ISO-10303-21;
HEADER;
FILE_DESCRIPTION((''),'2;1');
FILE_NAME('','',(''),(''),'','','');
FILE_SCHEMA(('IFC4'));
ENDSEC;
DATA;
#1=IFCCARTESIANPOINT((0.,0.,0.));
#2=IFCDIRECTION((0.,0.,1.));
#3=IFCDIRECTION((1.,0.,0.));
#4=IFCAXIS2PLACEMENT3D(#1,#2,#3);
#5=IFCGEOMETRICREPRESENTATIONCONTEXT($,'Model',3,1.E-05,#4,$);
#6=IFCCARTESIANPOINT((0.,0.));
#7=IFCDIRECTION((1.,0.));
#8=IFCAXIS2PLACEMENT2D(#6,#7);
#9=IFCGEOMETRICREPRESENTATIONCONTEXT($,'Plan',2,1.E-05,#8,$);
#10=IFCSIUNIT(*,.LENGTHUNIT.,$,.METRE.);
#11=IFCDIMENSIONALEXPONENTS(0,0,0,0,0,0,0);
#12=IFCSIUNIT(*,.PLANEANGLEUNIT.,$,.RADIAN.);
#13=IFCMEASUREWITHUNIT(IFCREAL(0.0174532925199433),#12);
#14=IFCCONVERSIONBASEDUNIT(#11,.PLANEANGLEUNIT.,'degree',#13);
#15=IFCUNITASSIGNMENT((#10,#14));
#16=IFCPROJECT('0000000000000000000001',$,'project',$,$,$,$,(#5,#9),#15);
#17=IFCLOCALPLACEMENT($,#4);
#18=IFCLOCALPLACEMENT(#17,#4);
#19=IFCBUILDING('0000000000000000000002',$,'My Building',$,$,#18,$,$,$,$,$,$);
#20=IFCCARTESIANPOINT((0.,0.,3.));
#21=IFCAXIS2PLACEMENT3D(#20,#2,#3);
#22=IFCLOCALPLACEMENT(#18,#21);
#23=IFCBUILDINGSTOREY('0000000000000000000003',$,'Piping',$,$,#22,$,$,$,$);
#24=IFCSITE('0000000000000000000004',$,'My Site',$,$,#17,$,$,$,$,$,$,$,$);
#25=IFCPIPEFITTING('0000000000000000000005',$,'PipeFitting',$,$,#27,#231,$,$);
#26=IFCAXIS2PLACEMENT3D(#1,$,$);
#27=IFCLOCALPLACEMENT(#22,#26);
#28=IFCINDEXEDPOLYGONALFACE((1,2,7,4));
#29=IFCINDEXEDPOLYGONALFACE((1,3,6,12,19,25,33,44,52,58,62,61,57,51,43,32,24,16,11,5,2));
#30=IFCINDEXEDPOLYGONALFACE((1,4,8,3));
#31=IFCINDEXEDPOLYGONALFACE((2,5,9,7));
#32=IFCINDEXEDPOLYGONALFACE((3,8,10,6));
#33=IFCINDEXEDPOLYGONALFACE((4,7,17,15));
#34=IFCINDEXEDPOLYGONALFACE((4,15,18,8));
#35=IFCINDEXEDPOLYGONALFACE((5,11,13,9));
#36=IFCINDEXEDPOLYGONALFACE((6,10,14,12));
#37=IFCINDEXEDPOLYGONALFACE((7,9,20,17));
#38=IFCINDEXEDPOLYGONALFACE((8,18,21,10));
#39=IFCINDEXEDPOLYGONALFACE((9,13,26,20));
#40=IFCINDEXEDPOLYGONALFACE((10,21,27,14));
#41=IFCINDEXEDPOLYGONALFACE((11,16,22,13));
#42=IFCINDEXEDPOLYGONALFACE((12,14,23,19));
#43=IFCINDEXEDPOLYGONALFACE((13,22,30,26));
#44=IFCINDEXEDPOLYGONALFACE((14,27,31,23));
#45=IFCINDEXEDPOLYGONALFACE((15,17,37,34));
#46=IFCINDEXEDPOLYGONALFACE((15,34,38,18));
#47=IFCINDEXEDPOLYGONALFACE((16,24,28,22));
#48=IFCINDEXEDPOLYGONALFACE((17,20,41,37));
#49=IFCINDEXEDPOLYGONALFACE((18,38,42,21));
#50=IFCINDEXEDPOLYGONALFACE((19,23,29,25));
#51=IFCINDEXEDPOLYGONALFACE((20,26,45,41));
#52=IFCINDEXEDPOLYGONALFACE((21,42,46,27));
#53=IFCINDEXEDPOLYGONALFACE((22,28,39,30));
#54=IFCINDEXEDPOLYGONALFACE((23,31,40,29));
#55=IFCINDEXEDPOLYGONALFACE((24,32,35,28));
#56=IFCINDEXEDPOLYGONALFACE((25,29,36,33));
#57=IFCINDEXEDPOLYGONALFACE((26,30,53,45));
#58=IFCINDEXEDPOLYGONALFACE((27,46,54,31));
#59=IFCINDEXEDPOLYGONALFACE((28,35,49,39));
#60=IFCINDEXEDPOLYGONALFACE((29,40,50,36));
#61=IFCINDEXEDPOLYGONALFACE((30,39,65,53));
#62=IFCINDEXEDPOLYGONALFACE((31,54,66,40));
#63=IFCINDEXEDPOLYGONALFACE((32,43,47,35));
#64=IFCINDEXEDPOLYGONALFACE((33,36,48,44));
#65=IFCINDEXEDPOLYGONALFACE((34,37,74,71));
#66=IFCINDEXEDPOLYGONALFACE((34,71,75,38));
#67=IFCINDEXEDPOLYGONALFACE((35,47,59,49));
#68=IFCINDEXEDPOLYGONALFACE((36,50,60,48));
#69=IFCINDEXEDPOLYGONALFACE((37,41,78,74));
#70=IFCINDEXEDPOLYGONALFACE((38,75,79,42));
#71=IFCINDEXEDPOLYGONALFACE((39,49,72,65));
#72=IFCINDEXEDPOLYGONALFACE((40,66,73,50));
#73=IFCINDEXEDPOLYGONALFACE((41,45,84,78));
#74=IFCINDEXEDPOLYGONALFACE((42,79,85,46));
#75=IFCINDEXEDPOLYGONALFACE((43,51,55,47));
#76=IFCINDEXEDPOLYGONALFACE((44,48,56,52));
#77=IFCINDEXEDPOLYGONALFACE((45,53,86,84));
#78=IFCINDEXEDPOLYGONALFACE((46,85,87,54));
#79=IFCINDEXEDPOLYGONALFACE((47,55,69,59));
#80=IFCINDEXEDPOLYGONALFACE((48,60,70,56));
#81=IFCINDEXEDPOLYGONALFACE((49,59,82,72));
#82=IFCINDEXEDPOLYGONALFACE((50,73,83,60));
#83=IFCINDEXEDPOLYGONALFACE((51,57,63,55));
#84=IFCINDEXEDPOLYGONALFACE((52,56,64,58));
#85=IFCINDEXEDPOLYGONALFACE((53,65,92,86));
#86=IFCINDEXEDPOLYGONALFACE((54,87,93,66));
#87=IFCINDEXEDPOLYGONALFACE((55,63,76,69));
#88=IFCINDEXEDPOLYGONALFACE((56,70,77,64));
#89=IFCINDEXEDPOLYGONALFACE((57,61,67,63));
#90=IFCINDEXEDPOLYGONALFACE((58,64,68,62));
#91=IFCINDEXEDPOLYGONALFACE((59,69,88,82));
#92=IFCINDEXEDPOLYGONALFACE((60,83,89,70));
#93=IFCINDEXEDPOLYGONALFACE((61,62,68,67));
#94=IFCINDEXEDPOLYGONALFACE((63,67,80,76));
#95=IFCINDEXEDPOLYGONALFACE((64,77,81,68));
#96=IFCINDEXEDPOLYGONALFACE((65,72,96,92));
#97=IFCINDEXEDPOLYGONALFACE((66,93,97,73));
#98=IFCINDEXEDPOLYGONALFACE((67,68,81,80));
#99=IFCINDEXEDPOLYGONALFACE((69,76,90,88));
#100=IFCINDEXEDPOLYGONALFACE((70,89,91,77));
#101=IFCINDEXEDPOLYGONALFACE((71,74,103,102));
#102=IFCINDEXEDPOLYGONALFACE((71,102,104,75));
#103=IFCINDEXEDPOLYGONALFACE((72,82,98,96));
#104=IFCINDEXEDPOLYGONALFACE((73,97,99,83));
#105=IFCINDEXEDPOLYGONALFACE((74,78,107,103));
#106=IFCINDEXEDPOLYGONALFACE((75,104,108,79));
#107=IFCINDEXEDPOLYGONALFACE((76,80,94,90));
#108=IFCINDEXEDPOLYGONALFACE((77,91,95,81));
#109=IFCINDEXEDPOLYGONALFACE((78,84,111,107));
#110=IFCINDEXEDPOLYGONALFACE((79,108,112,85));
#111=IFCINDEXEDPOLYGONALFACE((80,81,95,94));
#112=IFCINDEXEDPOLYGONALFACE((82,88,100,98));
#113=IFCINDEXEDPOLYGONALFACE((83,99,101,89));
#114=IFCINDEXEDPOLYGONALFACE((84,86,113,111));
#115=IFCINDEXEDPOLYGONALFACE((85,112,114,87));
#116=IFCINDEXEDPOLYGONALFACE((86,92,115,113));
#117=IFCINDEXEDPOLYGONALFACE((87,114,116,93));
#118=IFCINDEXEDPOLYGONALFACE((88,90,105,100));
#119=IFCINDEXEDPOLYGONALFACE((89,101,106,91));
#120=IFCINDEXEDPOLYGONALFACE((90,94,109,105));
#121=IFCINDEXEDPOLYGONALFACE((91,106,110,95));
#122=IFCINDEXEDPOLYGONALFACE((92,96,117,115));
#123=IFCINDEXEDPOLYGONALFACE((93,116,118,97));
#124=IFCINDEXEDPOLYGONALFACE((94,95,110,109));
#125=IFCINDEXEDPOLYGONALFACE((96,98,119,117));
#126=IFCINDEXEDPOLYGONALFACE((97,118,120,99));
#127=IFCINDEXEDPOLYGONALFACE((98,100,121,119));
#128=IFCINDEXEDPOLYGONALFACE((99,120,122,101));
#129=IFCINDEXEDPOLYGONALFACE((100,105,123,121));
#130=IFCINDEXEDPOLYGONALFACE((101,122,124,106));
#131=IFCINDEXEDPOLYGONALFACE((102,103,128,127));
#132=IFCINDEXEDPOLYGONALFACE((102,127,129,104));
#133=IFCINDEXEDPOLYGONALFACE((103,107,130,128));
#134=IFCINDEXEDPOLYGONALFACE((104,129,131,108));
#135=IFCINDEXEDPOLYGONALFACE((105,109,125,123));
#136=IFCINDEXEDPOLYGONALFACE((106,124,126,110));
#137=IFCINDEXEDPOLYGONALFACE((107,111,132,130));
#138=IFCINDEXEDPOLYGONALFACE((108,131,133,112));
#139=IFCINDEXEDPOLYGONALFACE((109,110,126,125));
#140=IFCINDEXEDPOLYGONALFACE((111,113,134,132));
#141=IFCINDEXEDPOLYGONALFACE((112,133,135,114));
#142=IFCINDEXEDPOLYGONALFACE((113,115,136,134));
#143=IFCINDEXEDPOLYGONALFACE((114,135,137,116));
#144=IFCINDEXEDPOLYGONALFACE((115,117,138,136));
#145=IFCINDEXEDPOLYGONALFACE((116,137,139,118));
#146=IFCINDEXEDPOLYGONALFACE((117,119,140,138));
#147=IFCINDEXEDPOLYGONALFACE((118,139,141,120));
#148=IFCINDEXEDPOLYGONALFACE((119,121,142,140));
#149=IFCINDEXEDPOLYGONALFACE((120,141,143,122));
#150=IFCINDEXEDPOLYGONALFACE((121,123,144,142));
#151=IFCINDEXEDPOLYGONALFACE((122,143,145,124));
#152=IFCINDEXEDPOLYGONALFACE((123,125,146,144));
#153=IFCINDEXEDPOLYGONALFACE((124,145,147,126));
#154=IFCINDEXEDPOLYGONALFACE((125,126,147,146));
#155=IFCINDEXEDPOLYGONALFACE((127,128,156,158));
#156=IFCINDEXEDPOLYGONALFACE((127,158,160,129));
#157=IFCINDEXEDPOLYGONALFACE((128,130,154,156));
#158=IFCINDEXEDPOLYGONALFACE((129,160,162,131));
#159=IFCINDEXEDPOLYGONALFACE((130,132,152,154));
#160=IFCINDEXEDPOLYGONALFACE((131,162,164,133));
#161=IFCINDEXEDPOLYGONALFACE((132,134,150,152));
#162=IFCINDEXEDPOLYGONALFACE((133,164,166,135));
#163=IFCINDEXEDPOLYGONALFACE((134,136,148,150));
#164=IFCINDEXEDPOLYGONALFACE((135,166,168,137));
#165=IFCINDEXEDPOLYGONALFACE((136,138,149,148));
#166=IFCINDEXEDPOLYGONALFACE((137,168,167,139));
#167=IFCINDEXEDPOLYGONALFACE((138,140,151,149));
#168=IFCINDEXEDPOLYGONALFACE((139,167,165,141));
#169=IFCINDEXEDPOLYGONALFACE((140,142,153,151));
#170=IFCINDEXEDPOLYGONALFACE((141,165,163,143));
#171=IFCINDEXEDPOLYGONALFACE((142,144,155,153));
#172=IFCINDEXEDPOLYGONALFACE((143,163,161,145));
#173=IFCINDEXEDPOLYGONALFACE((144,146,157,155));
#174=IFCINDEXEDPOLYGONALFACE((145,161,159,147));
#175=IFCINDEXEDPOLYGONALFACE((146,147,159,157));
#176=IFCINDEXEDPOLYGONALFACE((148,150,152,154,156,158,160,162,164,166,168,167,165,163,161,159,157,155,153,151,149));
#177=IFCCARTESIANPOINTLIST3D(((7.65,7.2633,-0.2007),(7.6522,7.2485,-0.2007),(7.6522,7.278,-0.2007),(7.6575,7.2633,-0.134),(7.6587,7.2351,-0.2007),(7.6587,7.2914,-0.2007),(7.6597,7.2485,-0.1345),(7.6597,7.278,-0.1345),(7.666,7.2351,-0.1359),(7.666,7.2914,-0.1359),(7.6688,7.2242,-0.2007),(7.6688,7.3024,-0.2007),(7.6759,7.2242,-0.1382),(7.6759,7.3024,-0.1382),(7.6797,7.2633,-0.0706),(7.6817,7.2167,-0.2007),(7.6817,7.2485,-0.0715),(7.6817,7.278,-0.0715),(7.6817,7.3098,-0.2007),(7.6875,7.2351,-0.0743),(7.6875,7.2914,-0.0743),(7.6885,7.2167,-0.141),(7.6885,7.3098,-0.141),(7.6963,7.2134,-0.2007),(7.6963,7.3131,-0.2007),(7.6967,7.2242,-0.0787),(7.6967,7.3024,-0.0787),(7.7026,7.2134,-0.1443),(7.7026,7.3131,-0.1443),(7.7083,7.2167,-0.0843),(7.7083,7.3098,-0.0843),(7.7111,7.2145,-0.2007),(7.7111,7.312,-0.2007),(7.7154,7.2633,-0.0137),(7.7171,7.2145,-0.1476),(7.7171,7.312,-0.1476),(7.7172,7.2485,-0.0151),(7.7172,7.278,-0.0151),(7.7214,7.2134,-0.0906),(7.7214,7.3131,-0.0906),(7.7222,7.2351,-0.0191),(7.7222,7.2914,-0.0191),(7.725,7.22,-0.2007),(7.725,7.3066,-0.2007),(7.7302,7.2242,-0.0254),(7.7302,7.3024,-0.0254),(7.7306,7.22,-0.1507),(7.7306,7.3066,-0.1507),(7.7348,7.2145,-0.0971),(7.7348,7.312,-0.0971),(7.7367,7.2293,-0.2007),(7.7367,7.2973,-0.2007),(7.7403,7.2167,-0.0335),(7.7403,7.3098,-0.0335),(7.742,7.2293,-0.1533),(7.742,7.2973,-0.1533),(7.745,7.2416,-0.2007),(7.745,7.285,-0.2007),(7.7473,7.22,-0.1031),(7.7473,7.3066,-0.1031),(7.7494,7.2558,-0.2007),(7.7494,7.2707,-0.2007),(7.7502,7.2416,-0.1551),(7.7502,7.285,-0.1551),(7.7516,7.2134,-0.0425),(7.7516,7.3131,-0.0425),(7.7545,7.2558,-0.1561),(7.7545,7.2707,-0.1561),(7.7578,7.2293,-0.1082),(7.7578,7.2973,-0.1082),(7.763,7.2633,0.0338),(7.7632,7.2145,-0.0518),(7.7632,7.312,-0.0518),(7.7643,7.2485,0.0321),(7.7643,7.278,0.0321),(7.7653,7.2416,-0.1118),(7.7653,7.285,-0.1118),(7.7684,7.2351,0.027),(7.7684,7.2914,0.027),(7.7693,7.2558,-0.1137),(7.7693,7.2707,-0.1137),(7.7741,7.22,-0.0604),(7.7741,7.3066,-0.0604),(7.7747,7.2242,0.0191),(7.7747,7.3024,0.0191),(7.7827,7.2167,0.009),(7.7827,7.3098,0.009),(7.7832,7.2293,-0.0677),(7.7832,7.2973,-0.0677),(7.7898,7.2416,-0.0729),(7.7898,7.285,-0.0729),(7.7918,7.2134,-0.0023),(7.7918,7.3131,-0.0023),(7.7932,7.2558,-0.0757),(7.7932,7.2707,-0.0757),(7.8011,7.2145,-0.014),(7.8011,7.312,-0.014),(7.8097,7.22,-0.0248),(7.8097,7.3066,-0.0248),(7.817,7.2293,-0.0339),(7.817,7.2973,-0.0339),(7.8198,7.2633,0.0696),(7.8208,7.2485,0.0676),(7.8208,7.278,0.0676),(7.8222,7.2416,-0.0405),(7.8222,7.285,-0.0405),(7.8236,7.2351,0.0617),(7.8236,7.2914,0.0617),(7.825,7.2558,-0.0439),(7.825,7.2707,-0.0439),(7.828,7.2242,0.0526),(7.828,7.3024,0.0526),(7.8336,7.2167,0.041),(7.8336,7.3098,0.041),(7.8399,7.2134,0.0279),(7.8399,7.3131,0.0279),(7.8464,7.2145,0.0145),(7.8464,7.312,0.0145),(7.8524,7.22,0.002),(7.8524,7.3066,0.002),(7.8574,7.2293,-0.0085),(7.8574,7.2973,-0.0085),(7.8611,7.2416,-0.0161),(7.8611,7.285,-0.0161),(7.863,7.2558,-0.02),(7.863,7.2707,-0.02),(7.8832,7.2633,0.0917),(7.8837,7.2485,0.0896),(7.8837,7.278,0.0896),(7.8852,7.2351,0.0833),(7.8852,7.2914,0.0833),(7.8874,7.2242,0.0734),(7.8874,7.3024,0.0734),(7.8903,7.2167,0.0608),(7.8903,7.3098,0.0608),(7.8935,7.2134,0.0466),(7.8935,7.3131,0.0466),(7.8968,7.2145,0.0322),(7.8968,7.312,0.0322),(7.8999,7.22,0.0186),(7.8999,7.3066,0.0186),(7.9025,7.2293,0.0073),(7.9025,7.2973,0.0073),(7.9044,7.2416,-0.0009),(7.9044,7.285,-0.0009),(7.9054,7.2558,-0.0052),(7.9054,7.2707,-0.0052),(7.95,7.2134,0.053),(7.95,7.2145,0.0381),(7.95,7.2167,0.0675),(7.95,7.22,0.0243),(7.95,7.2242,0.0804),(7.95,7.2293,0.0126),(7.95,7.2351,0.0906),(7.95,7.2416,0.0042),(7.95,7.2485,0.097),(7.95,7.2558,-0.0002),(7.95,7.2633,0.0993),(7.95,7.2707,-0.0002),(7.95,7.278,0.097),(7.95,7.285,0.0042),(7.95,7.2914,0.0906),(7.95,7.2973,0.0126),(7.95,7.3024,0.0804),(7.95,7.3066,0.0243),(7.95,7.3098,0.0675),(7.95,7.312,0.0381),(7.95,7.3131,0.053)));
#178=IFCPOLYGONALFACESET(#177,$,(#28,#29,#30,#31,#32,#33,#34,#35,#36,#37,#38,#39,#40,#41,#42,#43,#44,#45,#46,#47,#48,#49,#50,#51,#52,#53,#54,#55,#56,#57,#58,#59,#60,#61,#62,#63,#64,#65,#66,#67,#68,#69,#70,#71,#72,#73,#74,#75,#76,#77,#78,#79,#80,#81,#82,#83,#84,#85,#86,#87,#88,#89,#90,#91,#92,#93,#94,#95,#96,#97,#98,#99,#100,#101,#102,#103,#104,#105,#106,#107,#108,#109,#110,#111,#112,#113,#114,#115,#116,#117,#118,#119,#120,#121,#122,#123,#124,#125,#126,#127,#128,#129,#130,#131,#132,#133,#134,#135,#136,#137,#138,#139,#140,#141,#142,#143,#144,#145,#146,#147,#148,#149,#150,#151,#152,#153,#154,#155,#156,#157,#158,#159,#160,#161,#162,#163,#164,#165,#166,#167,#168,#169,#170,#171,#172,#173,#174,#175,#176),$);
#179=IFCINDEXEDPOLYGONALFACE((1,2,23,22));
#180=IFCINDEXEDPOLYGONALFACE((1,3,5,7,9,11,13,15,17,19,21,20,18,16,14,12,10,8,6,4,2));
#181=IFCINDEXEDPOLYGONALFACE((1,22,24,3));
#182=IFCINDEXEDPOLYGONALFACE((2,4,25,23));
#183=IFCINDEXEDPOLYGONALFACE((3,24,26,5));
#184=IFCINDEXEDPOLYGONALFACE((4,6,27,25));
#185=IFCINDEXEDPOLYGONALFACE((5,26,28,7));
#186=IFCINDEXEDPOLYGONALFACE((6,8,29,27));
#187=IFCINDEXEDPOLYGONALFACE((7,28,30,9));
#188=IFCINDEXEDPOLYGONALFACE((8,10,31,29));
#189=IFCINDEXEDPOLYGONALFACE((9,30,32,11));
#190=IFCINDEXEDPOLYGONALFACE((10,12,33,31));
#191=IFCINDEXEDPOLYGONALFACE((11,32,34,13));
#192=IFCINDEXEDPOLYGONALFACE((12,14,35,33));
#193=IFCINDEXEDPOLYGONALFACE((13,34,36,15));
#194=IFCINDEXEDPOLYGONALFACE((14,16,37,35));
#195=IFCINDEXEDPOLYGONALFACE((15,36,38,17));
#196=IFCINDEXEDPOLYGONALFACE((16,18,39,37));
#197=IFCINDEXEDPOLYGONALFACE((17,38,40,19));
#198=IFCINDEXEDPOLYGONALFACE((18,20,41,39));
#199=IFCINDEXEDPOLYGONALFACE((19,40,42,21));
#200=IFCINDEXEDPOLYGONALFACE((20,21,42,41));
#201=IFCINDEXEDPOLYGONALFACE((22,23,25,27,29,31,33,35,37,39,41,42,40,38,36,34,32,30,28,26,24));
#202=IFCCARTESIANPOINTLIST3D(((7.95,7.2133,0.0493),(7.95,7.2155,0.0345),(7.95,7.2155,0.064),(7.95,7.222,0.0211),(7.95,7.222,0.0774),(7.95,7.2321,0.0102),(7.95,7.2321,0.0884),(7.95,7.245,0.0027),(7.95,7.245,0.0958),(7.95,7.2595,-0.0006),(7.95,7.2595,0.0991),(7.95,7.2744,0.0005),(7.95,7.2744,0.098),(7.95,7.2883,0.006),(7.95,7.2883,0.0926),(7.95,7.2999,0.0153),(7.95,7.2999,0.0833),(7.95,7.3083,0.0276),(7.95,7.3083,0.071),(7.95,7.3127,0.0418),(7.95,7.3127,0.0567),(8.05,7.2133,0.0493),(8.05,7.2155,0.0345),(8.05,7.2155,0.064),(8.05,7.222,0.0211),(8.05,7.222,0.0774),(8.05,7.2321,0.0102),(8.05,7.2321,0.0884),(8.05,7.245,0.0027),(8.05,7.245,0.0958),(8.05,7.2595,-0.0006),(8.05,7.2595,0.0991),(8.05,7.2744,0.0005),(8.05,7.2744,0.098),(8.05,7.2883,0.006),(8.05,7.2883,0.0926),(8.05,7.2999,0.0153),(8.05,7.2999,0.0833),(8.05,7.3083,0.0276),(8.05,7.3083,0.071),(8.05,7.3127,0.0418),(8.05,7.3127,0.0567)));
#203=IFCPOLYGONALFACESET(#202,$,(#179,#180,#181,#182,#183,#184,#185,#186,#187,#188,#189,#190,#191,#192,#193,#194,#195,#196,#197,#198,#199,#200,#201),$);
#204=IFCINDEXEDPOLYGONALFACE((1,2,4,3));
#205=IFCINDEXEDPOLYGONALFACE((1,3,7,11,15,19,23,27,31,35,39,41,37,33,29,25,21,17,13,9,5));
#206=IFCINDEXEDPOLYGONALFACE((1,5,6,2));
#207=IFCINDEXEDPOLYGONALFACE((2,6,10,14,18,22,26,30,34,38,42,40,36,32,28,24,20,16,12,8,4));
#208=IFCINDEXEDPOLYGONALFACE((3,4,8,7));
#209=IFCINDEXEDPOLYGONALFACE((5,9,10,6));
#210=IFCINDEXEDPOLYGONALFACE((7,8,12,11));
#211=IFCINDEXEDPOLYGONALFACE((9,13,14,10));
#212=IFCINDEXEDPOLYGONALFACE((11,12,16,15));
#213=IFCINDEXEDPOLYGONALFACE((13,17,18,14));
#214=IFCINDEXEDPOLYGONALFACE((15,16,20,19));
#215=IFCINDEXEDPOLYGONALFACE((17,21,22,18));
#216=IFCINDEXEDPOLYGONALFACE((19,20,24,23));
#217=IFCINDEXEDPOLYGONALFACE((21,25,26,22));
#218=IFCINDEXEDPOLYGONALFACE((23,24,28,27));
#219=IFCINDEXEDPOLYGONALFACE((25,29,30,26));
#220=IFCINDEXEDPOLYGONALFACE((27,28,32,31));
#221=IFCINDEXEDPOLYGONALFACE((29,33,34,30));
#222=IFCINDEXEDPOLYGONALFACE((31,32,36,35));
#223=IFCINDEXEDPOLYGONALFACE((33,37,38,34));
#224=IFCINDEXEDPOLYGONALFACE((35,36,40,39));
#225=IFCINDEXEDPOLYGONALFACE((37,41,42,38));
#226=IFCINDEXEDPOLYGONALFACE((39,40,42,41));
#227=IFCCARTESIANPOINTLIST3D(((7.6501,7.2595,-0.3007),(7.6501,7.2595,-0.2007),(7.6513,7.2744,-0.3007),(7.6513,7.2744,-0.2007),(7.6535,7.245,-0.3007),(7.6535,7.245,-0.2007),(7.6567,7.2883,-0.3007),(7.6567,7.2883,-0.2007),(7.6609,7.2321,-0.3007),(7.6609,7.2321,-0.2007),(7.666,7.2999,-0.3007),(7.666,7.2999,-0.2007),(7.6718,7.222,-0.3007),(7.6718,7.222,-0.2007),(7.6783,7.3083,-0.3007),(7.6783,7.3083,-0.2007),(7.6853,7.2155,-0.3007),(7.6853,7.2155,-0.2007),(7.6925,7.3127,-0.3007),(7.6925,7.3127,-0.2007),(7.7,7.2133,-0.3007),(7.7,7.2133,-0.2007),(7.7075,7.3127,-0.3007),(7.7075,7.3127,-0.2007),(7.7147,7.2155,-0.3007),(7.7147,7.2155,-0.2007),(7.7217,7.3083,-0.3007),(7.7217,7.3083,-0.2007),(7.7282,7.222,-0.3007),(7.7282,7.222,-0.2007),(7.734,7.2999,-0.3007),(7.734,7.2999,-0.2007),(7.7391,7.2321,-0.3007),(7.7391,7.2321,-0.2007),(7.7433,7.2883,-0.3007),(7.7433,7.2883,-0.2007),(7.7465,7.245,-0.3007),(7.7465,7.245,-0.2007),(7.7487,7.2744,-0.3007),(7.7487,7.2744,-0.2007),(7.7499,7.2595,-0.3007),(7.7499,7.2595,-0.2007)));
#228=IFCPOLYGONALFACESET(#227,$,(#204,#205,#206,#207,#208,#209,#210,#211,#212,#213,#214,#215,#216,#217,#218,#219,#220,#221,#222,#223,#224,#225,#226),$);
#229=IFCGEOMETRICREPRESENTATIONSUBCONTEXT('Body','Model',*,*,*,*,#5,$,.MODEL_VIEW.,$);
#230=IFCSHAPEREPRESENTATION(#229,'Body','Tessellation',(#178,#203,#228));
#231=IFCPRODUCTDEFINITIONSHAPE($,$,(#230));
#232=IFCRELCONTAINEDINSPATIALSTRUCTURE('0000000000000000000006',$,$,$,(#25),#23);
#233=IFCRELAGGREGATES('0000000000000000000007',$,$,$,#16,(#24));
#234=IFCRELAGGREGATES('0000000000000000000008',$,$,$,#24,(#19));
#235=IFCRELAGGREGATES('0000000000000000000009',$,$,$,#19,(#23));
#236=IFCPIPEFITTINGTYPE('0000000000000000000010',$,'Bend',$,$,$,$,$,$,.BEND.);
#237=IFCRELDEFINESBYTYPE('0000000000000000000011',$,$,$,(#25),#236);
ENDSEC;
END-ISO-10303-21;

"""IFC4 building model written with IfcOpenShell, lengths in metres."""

from ifc_helpers import new_model, entity, si_unit, converted_unit, frame, origin_with_axes, origin_2d_with_axis, place, context, subcontext, project, spatial, circle, extrude, source, transform, mapped, type_object, type_shapes, element, save


model = new_model("IFC4")

# Units and contexts
model_context = context("Model", 3, precision=1e-05, world=origin_with_axes())
plan_context = context("Plan", 2, precision=1e-05, world=origin_2d_with_axis())
body_context = subcontext(model_context, "Body", "Model", "MODEL_VIEW")
ifc_project = project(units=[si_unit("LENGTHUNIT", "METRE"), converted_unit("PLANEANGLEUNIT", "degree", entity("IfcReal", 0.0174532925199433), si_unit("PLANEANGLEUNIT", "RADIAN"), dimensions=[0, 0, 0, 0, 0, 0, 0])], contexts=[model_context, plan_context])

# Site, building, storey
site_placement = place(None, origin_with_axes())
site = spatial("IfcSite", under=ifc_project, at=site_placement, Name="My Site")
building_placement = place(site_placement, origin_with_axes())
building = spatial("IfcBuilding", under=site, at=building_placement, Name="My Building")
storey_placement = place(building_placement, frame((0.0, 0.0, 3.0), z_axis=(0.0, 0.0, 1.0), x_axis=(1.0, 0.0, 0.0)))
storey = spatial("IfcBuildingStorey", under=building, at=storey_placement, Name="Piping")

# Pipe fitting
pipe_fitting_type_1 = type_object("IfcPipeFittingType", Name="Bend", PredefinedType="BEND")
shared_shape_1 = source(origin_with_axes(), body_context, "Body", "SolidModel", [
    entity("IfcSweptDiskSolid", entity("IfcIndexedPolyCurve", entity("IfcCartesianPointList3D", [[0.0, 0.0, 0.1], [0.0, -0.0732, 0.2768], [0.0, -0.25, 0.35]]), [entity("IfcArcIndex", [1, 2, 3])]), 0.05),
    extrude(circle(Radius=0.05), origin_with_axes(), (0.0, 0.0, 1.0), 0.1),
    extrude(circle(Radius=0.05), frame((0.0, -0.25, 0.35), z_axis=(0.0, -1.0, 0.0), x_axis=(1.0, 0.0, 0.0)), (0.0, 0.0, 1.0), 0.1),
])
type_shapes(pipe_fitting_type_1, [shared_shape_1])
for number, where, z_axis, x_axis, name in (
    (1, (8.05, 7.2633, 0.0493), (-1.0, 0.0, 0.0), (0.0, -1.0, 0.0), "PipeFitting"),
):
    element("IfcPipeFitting", number, at=place(storey_placement, frame(where, z_axis=z_axis, x_axis=x_axis)), inside=storey, type_object=pipe_fitting_type_1, Name=name, context=body_context, shape_type="MappedRepresentation", body=[
        mapped(shared_shape_1, transform((0.0, 0.0, 0.0), x_axis=(1.0, 0.0, 0.0), y_axis=(0.0, 1.0, 0.0), z_axis=(0.0, 0.0, 1.0), scale=1.0)),
    ])

save(model, "model.ifc")
